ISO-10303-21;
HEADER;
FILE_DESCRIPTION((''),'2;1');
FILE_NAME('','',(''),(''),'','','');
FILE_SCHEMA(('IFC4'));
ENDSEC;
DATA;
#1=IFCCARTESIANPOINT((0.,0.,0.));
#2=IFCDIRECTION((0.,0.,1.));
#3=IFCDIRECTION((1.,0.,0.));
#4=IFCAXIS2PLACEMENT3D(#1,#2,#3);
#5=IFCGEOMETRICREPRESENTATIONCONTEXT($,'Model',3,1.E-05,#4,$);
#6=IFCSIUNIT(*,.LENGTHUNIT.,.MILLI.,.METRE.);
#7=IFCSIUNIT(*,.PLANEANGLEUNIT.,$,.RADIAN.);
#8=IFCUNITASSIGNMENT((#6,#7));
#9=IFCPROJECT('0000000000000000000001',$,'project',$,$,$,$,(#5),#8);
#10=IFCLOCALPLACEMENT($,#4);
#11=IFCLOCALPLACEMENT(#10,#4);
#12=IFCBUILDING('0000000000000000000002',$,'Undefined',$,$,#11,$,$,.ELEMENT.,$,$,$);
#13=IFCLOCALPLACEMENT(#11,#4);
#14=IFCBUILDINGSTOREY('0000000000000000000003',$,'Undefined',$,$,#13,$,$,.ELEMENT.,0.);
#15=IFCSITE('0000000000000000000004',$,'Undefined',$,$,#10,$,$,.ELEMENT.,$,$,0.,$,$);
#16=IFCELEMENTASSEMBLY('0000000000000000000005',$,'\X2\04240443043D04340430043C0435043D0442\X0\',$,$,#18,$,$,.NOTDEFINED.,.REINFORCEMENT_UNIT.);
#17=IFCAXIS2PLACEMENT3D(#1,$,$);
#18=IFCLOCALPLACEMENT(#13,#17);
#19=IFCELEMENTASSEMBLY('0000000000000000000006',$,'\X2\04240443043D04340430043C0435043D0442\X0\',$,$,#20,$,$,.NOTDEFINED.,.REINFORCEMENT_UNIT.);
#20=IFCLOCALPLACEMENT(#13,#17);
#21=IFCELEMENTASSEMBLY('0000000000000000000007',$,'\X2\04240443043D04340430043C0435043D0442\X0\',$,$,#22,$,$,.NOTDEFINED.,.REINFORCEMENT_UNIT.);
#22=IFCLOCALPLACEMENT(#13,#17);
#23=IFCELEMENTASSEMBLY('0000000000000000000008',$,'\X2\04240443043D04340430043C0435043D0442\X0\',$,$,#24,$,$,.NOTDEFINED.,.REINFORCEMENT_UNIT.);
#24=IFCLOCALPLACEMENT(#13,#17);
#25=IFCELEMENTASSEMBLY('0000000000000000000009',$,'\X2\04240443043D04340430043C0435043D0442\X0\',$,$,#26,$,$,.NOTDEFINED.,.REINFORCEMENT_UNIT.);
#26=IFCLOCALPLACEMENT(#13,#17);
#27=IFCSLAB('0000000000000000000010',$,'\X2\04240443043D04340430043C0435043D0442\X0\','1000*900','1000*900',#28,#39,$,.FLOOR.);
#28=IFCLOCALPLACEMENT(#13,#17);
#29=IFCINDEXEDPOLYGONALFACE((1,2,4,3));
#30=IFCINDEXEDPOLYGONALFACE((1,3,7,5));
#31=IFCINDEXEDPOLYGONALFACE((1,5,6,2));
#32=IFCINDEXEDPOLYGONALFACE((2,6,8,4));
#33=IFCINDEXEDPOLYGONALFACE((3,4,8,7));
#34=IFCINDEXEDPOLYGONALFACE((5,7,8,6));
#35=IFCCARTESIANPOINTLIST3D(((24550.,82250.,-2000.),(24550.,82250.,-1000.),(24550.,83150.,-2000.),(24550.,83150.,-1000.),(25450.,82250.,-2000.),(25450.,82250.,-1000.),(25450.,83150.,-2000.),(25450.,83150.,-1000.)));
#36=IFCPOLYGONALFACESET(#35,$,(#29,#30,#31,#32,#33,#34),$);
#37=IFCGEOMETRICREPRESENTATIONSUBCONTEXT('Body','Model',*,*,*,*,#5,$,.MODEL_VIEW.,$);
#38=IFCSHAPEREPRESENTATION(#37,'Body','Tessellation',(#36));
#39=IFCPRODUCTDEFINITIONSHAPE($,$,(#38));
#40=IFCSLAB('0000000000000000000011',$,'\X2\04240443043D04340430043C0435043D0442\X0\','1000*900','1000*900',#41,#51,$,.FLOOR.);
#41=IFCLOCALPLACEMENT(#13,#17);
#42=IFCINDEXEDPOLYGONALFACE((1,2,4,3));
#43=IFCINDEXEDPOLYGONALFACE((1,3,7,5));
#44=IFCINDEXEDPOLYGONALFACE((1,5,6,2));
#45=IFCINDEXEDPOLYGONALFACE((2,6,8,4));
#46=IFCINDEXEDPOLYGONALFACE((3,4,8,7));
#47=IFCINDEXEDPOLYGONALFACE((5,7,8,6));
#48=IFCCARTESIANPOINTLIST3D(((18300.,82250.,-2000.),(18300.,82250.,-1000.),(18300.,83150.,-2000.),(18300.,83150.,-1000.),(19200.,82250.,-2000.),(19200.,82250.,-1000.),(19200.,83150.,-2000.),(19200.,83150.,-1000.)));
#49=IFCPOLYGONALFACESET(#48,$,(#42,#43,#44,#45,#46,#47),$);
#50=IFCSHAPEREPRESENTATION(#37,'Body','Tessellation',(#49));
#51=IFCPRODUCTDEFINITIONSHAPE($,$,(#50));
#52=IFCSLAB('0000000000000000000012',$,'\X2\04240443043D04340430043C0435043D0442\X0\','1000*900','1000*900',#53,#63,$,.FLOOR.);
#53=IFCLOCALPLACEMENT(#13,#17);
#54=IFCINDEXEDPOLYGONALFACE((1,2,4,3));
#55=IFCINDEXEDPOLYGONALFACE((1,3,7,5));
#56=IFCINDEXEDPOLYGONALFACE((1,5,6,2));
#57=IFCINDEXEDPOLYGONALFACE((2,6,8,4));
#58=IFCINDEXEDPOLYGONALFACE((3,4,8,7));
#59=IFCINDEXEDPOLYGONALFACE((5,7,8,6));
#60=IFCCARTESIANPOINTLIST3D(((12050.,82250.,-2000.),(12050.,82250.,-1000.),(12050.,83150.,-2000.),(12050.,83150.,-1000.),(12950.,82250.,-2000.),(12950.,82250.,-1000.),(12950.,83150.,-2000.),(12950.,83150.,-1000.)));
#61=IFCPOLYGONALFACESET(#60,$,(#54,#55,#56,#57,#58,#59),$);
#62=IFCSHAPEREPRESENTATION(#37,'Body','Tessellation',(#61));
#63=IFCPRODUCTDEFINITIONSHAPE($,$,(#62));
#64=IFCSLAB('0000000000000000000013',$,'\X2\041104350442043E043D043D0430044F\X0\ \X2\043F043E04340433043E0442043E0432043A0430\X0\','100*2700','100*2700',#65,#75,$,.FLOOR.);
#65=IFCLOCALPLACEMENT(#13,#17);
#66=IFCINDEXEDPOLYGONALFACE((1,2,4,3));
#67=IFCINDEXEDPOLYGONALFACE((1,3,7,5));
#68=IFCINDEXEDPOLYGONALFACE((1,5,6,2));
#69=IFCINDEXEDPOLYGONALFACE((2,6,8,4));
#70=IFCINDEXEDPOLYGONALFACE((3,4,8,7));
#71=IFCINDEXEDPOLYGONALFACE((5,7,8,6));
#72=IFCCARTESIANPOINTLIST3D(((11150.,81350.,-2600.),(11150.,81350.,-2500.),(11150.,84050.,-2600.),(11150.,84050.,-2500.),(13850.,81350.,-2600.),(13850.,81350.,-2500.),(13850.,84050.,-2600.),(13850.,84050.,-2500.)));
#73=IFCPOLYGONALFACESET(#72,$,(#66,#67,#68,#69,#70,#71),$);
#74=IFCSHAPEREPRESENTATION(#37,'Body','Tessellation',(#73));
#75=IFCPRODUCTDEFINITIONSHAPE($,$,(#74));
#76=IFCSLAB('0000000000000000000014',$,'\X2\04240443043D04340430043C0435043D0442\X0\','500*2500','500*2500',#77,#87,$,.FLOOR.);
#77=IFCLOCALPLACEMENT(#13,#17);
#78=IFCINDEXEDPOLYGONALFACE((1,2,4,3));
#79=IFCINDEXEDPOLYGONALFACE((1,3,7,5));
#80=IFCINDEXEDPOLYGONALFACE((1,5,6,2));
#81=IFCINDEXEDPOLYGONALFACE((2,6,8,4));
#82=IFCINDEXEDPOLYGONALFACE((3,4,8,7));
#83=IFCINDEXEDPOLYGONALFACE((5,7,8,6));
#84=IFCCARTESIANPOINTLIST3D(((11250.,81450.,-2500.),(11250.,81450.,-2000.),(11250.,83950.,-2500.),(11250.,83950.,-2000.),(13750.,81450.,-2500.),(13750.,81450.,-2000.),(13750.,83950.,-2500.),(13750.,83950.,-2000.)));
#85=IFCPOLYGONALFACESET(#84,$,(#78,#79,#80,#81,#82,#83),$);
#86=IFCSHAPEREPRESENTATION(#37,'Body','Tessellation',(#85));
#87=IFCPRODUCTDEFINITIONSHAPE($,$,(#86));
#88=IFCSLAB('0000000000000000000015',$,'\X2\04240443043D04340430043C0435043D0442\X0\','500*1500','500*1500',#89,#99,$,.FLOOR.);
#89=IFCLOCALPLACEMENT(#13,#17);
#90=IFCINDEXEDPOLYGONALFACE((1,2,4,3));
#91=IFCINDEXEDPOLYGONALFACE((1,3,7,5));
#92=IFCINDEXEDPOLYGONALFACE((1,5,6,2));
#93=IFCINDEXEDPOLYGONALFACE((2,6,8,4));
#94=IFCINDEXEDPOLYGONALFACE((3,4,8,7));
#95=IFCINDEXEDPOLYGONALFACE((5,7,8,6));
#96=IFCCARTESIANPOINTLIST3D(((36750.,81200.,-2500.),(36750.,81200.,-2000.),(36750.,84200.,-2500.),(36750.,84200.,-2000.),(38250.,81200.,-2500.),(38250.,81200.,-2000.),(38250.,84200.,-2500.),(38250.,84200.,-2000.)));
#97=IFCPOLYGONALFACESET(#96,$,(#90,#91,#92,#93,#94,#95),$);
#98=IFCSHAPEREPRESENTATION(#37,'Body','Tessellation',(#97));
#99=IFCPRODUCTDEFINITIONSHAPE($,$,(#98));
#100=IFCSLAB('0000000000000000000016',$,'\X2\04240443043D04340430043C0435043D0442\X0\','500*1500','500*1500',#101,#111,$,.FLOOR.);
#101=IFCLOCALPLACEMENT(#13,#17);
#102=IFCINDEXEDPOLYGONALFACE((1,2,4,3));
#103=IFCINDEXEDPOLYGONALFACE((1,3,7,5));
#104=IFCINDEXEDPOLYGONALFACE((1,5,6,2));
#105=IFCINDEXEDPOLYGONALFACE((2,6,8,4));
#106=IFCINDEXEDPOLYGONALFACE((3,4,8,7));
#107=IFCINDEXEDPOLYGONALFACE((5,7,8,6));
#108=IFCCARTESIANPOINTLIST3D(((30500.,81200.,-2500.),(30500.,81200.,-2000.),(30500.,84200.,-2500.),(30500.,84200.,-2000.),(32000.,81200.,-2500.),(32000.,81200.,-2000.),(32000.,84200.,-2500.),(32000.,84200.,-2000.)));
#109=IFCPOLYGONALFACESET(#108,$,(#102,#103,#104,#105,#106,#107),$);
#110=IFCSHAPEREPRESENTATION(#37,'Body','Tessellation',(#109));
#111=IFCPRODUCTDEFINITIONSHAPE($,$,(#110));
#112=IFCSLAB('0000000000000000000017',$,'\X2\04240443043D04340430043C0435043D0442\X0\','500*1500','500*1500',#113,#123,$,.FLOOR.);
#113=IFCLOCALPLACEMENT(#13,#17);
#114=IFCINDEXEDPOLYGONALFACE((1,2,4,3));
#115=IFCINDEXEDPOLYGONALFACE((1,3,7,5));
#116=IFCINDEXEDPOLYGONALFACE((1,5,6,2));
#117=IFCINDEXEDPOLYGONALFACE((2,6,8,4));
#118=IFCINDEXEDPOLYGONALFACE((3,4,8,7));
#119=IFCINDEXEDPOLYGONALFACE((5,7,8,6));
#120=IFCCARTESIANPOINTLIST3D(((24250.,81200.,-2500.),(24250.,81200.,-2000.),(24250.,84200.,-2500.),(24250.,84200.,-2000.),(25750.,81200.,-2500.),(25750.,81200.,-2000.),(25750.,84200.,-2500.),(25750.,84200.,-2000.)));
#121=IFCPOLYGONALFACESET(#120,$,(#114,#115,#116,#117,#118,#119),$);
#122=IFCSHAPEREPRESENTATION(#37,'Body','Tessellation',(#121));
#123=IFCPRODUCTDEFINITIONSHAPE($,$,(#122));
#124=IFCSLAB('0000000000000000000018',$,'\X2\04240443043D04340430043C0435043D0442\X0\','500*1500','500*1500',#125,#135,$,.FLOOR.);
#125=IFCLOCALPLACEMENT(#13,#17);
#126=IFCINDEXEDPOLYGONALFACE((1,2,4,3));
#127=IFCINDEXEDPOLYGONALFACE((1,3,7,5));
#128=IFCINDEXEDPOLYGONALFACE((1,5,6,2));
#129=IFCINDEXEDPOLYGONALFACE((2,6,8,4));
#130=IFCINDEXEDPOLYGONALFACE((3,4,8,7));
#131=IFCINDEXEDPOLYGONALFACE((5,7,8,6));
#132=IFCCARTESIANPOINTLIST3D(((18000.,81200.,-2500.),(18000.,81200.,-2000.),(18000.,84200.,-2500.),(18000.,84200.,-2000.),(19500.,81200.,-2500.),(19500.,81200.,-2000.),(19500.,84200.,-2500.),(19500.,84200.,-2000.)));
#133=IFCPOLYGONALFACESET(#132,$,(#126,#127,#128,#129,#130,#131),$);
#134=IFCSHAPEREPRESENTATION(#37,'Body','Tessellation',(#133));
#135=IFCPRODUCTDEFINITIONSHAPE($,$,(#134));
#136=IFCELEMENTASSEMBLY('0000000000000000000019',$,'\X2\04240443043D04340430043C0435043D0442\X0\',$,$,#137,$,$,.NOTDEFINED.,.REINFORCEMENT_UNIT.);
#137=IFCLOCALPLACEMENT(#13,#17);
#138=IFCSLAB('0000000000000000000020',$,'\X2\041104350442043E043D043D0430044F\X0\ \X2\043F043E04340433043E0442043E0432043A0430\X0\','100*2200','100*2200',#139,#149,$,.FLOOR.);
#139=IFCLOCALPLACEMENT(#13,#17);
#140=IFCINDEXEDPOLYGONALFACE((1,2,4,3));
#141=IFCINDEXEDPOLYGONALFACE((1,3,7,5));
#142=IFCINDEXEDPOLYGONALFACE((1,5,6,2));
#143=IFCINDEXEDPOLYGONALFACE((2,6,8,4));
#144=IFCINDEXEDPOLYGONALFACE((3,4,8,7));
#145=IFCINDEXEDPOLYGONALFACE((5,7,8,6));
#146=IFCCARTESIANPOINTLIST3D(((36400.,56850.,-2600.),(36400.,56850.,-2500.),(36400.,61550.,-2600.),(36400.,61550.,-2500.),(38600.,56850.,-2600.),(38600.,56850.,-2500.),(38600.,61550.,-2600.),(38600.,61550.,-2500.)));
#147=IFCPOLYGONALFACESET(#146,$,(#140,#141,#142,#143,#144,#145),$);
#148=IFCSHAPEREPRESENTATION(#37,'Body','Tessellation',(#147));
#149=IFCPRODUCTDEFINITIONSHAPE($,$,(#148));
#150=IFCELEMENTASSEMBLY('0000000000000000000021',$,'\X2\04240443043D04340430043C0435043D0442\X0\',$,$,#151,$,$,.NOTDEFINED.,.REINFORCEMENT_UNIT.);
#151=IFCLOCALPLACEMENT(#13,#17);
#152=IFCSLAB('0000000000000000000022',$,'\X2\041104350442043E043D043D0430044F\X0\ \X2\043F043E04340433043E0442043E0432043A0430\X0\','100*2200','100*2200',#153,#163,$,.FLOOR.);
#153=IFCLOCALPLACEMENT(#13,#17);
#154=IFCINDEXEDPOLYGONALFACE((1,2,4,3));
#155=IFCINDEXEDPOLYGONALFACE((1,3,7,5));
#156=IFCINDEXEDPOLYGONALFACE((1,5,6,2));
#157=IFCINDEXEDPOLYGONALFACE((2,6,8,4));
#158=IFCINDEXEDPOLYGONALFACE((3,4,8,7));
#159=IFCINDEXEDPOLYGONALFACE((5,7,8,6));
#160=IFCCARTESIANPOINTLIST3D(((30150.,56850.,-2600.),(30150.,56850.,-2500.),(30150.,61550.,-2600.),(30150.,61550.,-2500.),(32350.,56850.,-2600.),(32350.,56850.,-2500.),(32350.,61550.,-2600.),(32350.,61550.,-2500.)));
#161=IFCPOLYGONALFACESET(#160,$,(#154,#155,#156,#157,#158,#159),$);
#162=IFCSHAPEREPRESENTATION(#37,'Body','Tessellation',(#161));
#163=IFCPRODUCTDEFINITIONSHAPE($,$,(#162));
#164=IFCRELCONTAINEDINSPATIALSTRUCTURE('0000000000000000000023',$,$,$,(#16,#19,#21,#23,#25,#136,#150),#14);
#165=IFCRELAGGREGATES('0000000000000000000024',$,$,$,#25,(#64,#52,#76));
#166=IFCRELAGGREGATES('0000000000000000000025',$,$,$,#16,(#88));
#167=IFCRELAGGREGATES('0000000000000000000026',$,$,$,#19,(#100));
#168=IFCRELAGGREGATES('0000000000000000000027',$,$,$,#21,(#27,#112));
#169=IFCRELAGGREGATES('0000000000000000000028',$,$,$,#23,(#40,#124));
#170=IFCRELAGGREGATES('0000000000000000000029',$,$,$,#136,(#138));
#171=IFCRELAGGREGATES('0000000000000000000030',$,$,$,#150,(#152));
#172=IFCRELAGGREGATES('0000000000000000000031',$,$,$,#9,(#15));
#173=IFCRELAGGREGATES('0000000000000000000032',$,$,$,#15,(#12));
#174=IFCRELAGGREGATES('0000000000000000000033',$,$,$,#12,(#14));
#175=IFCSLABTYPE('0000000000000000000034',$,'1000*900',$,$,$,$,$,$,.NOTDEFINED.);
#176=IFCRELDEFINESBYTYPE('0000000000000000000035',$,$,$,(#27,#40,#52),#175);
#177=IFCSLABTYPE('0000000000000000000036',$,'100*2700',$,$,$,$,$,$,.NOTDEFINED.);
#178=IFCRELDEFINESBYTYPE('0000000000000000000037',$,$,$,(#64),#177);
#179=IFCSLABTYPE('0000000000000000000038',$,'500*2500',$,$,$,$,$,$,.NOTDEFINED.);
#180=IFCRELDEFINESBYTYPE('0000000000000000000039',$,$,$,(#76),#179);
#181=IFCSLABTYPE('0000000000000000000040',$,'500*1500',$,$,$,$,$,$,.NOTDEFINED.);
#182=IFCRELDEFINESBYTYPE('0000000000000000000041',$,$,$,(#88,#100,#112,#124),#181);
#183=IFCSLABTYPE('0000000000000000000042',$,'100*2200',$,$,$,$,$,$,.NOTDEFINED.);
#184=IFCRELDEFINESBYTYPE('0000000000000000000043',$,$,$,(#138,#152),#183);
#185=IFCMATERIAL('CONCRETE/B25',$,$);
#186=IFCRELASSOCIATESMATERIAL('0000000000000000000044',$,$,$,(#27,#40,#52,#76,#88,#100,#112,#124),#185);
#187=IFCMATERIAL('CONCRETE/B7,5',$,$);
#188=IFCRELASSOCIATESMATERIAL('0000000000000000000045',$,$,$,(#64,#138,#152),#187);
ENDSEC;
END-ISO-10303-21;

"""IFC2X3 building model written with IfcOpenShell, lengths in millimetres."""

from ifc_helpers import new_model, si_unit, frame, origin_with_axes, place, context, subcontext, project, spatial, polyline, outline, extrude, material, type_object, element, aggregate, save


model = new_model("IFC2X3")

# Units and contexts
model_context = context("Model", 3, precision=1e-05, world=origin_with_axes())
body_context = subcontext(model_context, "Body", "Model", "MODEL_VIEW")
ifc_project = project(units=[si_unit("LENGTHUNIT", "METRE", prefix="MILLI"), si_unit("PLANEANGLEUNIT", "RADIAN")], contexts=[model_context])

# Site, building, storey
site_placement = place(None, origin_with_axes())
site = spatial("IfcSite", under=ifc_project, at=site_placement, Name="Undefined", CompositionType="ELEMENT", RefElevation=0.0)
building_placement = place(site_placement, origin_with_axes())
building = spatial("IfcBuilding", under=site, at=building_placement, Name="Undefined", CompositionType="ELEMENT")
storey_placement = place(building_placement, origin_with_axes())
storey = spatial("IfcBuildingStorey", under=building, at=storey_placement, Name="Undefined", CompositionType="ELEMENT", Elevation=0.0)

# Element assemblies
assembly_1_placement = place(storey_placement, origin_with_axes())
assembly_1 = element("IfcElementAssembly", 1, at=assembly_1_placement, inside=storey, Name="Фундамент", AssemblyPlace="NOTDEFINED", PredefinedType="REINFORCEMENT_UNIT")
ifc_material_1 = material(Name="CONCRETE/B25")
assembly_2_placement = place(storey_placement, origin_with_axes())
assembly_2 = element("IfcElementAssembly", 2, at=assembly_2_placement, inside=storey, Name="Фундамент", AssemblyPlace="NOTDEFINED", PredefinedType="REINFORCEMENT_UNIT")
assembly_3_placement = place(storey_placement, origin_with_axes())
assembly_3 = element("IfcElementAssembly", 3, at=assembly_3_placement, inside=storey, Name="Фундамент", AssemblyPlace="NOTDEFINED", PredefinedType="REINFORCEMENT_UNIT")
assembly_4_placement = place(storey_placement, origin_with_axes())
assembly_4 = element("IfcElementAssembly", 4, at=assembly_4_placement, inside=storey, Name="Фундамент", AssemblyPlace="NOTDEFINED", PredefinedType="REINFORCEMENT_UNIT")
assembly_5_placement = place(storey_placement, origin_with_axes())
assembly_5 = element("IfcElementAssembly", 5, at=assembly_5_placement, inside=storey, Name="Фундамент", AssemblyPlace="NOTDEFINED", PredefinedType="REINFORCEMENT_UNIT")

# Slabs
ifc_material_2 = material(Name="CONCRETE/B7,5")
slab_type_1 = type_object("IfcSlabType", Name="1000*900", PredefinedType="NOTDEFINED")
slab_1_placement = place(assembly_3_placement, frame((24550.0, 83150.0, -1500.0), z_axis=(0.0, 0.0, 1.0), x_axis=(0.0, -1.0, 0.0)))
slab_1 = element("IfcSlab", 6, at=slab_1_placement, type_object=slab_type_1, material=ifc_material_1, Name="Фундамент", Description="1000*900", ObjectType="1000*900", PredefinedType="FLOOR", context=body_context, shape_type="SweptSolid", body=[
    extrude(outline(polyline([(0.0, 0.0), (900.0, 0.0), (900.0, 900.0), (0.0, 900.0), (0.0, 0.0)])), frame((0.0, 0.0, -500.0), z_axis=(0.0, 0.0, 1.0), x_axis=(1.0, 0.0, 0.0)), (0.0, 0.0, 1.0), 1000.0),
])
slab_2_placement = place(assembly_4_placement, frame((18300.0, 83150.0, -1500.0), z_axis=(0.0, 0.0, 1.0), x_axis=(0.0, -1.0, 0.0)))
slab_2 = element("IfcSlab", 7, at=slab_2_placement, type_object=slab_type_1, material=ifc_material_1, Name="Фундамент", Description="1000*900", ObjectType="1000*900", PredefinedType="FLOOR", context=body_context, shape_type="SweptSolid", body=[
    extrude(outline(polyline([(0.0, 0.0), (900.0, 0.0), (900.0, 900.0), (0.0, 900.0), (0.0, 0.0)])), frame((0.0, 0.0, -500.0), z_axis=(0.0, 0.0, 1.0), x_axis=(1.0, 0.0, 0.0)), (0.0, 0.0, 1.0), 1000.0),
])
slab_3_placement = place(assembly_5_placement, frame((12050.0, 83150.0, -1500.0), z_axis=(0.0, 0.0, 1.0), x_axis=(0.0, -1.0, 0.0)))
slab_3 = element("IfcSlab", 8, at=slab_3_placement, type_object=slab_type_1, material=ifc_material_1, Name="Фундамент", Description="1000*900", ObjectType="1000*900", PredefinedType="FLOOR", context=body_context, shape_type="SweptSolid", body=[
    extrude(outline(polyline([(0.0, 0.0), (900.0, 0.0), (900.0, 900.0), (0.0, 900.0), (0.0, 0.0)])), frame((0.0, 0.0, -500.0), z_axis=(0.0, 0.0, 1.0), x_axis=(1.0, 0.0, 0.0)), (0.0, 0.0, 1.0), 1000.0),
])
slab_type_2 = type_object("IfcSlabType", Name="100*2700", PredefinedType="NOTDEFINED")
slab_4_placement = place(assembly_5_placement, frame((11150.0, 84050.0, -2550.0), z_axis=(0.0, 0.0, 1.0), x_axis=(0.0, -1.0, 0.0)))
slab_4 = element("IfcSlab", 9, at=slab_4_placement, type_object=slab_type_2, material=ifc_material_2, Name="Бетонная подготовка", Description="100*2700", ObjectType="100*2700", PredefinedType="FLOOR", context=body_context, shape_type="SweptSolid", body=[
    extrude(outline(polyline([(0.0, 0.0), (2700.0, 0.0), (2700.0, 2700.0), (0.0, 2700.0), (0.0, 0.0)])), frame((0.0, 0.0, -50.0), z_axis=(0.0, 0.0, 1.0), x_axis=(1.0, 0.0, 0.0)), (0.0, 0.0, 1.0), 100.0),
])
slab_type_3 = type_object("IfcSlabType", Name="500*2500", PredefinedType="NOTDEFINED")
slab_5_placement = place(assembly_5_placement, frame((11250.0, 83950.0, -2250.0), z_axis=(0.0, 0.0, 1.0), x_axis=(0.0, -1.0, 0.0)))
slab_5 = element("IfcSlab", 10, at=slab_5_placement, type_object=slab_type_3, material=ifc_material_1, Name="Фундамент", Description="500*2500", ObjectType="500*2500", PredefinedType="FLOOR", context=body_context, shape_type="SweptSolid", body=[
    extrude(outline(polyline([(0.0, 0.0), (2500.0, 0.0), (2500.0, 2500.0), (0.0, 2500.0), (0.0, 0.0)])), frame((0.0, 0.0, -250.0), z_axis=(0.0, 0.0, 1.0), x_axis=(1.0, 0.0, 0.0)), (0.0, 0.0, 1.0), 500.0),
])
aggregate(assembly_5, [slab_4, slab_3, slab_5])
slab_type_4 = type_object("IfcSlabType", Name="500*1500", PredefinedType="NOTDEFINED")
slab_6_placement = place(assembly_1_placement, frame((36750.0, 84200.0, -2250.0), z_axis=(0.0, 0.0, 1.0), x_axis=(0.0, -1.0, 0.0)))
slab_6 = element("IfcSlab", 11, at=slab_6_placement, type_object=slab_type_4, material=ifc_material_1, Name="Фундамент", Description="500*1500", ObjectType="500*1500", PredefinedType="FLOOR", context=body_context, shape_type="SweptSolid", body=[
    extrude(outline(polyline([(0.0, 0.0), (3000.0, 0.0), (3000.0, 1500.0), (0.0, 1500.0), (0.0, 0.0)])), frame((0.0, 0.0, -250.0), z_axis=(0.0, 0.0, 1.0), x_axis=(1.0, 0.0, 0.0)), (0.0, 0.0, 1.0), 500.0),
])
aggregate(assembly_1, [slab_6])
slab_7_placement = place(assembly_2_placement, frame((30500.0, 84200.0, -2250.0), z_axis=(0.0, 0.0, 1.0), x_axis=(0.0, -1.0, 0.0)))
slab_7 = element("IfcSlab", 12, at=slab_7_placement, type_object=slab_type_4, material=ifc_material_1, Name="Фундамент", Description="500*1500", ObjectType="500*1500", PredefinedType="FLOOR", context=body_context, shape_type="SweptSolid", body=[
    extrude(outline(polyline([(0.0, 0.0), (3000.0, 0.0), (3000.0, 1500.0), (0.0, 1500.0), (0.0, 0.0)])), frame((0.0, 0.0, -250.0), z_axis=(0.0, 0.0, 1.0), x_axis=(1.0, 0.0, 0.0)), (0.0, 0.0, 1.0), 500.0),
])
aggregate(assembly_2, [slab_7])
slab_8_placement = place(assembly_3_placement, frame((24250.0, 84200.0, -2250.0), z_axis=(0.0, 0.0, 1.0), x_axis=(0.0, -1.0, 0.0)))
slab_8 = element("IfcSlab", 13, at=slab_8_placement, type_object=slab_type_4, material=ifc_material_1, Name="Фундамент", Description="500*1500", ObjectType="500*1500", PredefinedType="FLOOR", context=body_context, shape_type="SweptSolid", body=[
    extrude(outline(polyline([(0.0, 0.0), (3000.0, 0.0), (3000.0, 1500.0), (0.0, 1500.0), (0.0, 0.0)])), frame((0.0, 0.0, -250.0), z_axis=(0.0, 0.0, 1.0), x_axis=(1.0, 0.0, 0.0)), (0.0, 0.0, 1.0), 500.0),
])
aggregate(assembly_3, [slab_1, slab_8])
slab_9_placement = place(assembly_4_placement, frame((18000.0, 84200.0, -2250.0), z_axis=(0.0, 0.0, 1.0), x_axis=(0.0, -1.0, 0.0)))
slab_9 = element("IfcSlab", 14, at=slab_9_placement, type_object=slab_type_4, material=ifc_material_1, Name="Фундамент", Description="500*1500", ObjectType="500*1500", PredefinedType="FLOOR", context=body_context, shape_type="SweptSolid", body=[
    extrude(outline(polyline([(0.0, 0.0), (3000.0, 0.0), (3000.0, 1500.0), (0.0, 1500.0), (0.0, 0.0)])), frame((0.0, 0.0, -250.0), z_axis=(0.0, 0.0, 1.0), x_axis=(1.0, 0.0, 0.0)), (0.0, 0.0, 1.0), 500.0),
])
aggregate(assembly_4, [slab_2, slab_9])

# Element assemblies, slabs
assembly_6_placement = place(storey_placement, origin_with_axes())
assembly_6 = element("IfcElementAssembly", 15, at=assembly_6_placement, inside=storey, Name="Фундамент", AssemblyPlace="NOTDEFINED", PredefinedType="REINFORCEMENT_UNIT")
slab_type_5 = type_object("IfcSlabType", Name="100*2200", PredefinedType="NOTDEFINED")
slab_10_placement = place(assembly_6_placement, frame((36400.0, 61550.0, -2550.0), z_axis=(0.0, 0.0, 1.0), x_axis=(0.0, -1.0, 0.0)))
slab_10 = element("IfcSlab", 16, at=slab_10_placement, type_object=slab_type_5, material=ifc_material_2, Name="Бетонная подготовка", Description="100*2200", ObjectType="100*2200", PredefinedType="FLOOR", context=body_context, shape_type="SweptSolid", body=[
    extrude(outline(polyline([(0.0, 0.0), (4700.0, 0.0), (4700.0, 2200.0), (0.0, 2200.0), (0.0, 0.0)])), frame((0.0, 0.0, -50.0), z_axis=(0.0, 0.0, 1.0), x_axis=(1.0, 0.0, 0.0)), (0.0, 0.0, 1.0), 100.0),
])
aggregate(assembly_6, [slab_10])
assembly_7_placement = place(storey_placement, origin_with_axes())
assembly_7 = element("IfcElementAssembly", 17, at=assembly_7_placement, inside=storey, Name="Фундамент", AssemblyPlace="NOTDEFINED", PredefinedType="REINFORCEMENT_UNIT")
slab_11_placement = place(assembly_7_placement, frame((30150.0, 61550.0, -2550.0), z_axis=(0.0, 0.0, 1.0), x_axis=(0.0, -1.0, 0.0)))
slab_11 = element("IfcSlab", 18, at=slab_11_placement, type_object=slab_type_5, material=ifc_material_2, Name="Бетонная подготовка", Description="100*2200", ObjectType="100*2200", PredefinedType="FLOOR", context=body_context, shape_type="SweptSolid", body=[
    extrude(outline(polyline([(0.0, 0.0), (4700.0, 0.0), (4700.0, 2200.0), (0.0, 2200.0), (0.0, 0.0)])), frame((0.0, 0.0, -50.0), z_axis=(0.0, 0.0, 1.0), x_axis=(1.0, 0.0, 0.0)), (0.0, 0.0, 1.0), 100.0),
])
aggregate(assembly_7, [slab_11])

save(model, "model.ifc")
